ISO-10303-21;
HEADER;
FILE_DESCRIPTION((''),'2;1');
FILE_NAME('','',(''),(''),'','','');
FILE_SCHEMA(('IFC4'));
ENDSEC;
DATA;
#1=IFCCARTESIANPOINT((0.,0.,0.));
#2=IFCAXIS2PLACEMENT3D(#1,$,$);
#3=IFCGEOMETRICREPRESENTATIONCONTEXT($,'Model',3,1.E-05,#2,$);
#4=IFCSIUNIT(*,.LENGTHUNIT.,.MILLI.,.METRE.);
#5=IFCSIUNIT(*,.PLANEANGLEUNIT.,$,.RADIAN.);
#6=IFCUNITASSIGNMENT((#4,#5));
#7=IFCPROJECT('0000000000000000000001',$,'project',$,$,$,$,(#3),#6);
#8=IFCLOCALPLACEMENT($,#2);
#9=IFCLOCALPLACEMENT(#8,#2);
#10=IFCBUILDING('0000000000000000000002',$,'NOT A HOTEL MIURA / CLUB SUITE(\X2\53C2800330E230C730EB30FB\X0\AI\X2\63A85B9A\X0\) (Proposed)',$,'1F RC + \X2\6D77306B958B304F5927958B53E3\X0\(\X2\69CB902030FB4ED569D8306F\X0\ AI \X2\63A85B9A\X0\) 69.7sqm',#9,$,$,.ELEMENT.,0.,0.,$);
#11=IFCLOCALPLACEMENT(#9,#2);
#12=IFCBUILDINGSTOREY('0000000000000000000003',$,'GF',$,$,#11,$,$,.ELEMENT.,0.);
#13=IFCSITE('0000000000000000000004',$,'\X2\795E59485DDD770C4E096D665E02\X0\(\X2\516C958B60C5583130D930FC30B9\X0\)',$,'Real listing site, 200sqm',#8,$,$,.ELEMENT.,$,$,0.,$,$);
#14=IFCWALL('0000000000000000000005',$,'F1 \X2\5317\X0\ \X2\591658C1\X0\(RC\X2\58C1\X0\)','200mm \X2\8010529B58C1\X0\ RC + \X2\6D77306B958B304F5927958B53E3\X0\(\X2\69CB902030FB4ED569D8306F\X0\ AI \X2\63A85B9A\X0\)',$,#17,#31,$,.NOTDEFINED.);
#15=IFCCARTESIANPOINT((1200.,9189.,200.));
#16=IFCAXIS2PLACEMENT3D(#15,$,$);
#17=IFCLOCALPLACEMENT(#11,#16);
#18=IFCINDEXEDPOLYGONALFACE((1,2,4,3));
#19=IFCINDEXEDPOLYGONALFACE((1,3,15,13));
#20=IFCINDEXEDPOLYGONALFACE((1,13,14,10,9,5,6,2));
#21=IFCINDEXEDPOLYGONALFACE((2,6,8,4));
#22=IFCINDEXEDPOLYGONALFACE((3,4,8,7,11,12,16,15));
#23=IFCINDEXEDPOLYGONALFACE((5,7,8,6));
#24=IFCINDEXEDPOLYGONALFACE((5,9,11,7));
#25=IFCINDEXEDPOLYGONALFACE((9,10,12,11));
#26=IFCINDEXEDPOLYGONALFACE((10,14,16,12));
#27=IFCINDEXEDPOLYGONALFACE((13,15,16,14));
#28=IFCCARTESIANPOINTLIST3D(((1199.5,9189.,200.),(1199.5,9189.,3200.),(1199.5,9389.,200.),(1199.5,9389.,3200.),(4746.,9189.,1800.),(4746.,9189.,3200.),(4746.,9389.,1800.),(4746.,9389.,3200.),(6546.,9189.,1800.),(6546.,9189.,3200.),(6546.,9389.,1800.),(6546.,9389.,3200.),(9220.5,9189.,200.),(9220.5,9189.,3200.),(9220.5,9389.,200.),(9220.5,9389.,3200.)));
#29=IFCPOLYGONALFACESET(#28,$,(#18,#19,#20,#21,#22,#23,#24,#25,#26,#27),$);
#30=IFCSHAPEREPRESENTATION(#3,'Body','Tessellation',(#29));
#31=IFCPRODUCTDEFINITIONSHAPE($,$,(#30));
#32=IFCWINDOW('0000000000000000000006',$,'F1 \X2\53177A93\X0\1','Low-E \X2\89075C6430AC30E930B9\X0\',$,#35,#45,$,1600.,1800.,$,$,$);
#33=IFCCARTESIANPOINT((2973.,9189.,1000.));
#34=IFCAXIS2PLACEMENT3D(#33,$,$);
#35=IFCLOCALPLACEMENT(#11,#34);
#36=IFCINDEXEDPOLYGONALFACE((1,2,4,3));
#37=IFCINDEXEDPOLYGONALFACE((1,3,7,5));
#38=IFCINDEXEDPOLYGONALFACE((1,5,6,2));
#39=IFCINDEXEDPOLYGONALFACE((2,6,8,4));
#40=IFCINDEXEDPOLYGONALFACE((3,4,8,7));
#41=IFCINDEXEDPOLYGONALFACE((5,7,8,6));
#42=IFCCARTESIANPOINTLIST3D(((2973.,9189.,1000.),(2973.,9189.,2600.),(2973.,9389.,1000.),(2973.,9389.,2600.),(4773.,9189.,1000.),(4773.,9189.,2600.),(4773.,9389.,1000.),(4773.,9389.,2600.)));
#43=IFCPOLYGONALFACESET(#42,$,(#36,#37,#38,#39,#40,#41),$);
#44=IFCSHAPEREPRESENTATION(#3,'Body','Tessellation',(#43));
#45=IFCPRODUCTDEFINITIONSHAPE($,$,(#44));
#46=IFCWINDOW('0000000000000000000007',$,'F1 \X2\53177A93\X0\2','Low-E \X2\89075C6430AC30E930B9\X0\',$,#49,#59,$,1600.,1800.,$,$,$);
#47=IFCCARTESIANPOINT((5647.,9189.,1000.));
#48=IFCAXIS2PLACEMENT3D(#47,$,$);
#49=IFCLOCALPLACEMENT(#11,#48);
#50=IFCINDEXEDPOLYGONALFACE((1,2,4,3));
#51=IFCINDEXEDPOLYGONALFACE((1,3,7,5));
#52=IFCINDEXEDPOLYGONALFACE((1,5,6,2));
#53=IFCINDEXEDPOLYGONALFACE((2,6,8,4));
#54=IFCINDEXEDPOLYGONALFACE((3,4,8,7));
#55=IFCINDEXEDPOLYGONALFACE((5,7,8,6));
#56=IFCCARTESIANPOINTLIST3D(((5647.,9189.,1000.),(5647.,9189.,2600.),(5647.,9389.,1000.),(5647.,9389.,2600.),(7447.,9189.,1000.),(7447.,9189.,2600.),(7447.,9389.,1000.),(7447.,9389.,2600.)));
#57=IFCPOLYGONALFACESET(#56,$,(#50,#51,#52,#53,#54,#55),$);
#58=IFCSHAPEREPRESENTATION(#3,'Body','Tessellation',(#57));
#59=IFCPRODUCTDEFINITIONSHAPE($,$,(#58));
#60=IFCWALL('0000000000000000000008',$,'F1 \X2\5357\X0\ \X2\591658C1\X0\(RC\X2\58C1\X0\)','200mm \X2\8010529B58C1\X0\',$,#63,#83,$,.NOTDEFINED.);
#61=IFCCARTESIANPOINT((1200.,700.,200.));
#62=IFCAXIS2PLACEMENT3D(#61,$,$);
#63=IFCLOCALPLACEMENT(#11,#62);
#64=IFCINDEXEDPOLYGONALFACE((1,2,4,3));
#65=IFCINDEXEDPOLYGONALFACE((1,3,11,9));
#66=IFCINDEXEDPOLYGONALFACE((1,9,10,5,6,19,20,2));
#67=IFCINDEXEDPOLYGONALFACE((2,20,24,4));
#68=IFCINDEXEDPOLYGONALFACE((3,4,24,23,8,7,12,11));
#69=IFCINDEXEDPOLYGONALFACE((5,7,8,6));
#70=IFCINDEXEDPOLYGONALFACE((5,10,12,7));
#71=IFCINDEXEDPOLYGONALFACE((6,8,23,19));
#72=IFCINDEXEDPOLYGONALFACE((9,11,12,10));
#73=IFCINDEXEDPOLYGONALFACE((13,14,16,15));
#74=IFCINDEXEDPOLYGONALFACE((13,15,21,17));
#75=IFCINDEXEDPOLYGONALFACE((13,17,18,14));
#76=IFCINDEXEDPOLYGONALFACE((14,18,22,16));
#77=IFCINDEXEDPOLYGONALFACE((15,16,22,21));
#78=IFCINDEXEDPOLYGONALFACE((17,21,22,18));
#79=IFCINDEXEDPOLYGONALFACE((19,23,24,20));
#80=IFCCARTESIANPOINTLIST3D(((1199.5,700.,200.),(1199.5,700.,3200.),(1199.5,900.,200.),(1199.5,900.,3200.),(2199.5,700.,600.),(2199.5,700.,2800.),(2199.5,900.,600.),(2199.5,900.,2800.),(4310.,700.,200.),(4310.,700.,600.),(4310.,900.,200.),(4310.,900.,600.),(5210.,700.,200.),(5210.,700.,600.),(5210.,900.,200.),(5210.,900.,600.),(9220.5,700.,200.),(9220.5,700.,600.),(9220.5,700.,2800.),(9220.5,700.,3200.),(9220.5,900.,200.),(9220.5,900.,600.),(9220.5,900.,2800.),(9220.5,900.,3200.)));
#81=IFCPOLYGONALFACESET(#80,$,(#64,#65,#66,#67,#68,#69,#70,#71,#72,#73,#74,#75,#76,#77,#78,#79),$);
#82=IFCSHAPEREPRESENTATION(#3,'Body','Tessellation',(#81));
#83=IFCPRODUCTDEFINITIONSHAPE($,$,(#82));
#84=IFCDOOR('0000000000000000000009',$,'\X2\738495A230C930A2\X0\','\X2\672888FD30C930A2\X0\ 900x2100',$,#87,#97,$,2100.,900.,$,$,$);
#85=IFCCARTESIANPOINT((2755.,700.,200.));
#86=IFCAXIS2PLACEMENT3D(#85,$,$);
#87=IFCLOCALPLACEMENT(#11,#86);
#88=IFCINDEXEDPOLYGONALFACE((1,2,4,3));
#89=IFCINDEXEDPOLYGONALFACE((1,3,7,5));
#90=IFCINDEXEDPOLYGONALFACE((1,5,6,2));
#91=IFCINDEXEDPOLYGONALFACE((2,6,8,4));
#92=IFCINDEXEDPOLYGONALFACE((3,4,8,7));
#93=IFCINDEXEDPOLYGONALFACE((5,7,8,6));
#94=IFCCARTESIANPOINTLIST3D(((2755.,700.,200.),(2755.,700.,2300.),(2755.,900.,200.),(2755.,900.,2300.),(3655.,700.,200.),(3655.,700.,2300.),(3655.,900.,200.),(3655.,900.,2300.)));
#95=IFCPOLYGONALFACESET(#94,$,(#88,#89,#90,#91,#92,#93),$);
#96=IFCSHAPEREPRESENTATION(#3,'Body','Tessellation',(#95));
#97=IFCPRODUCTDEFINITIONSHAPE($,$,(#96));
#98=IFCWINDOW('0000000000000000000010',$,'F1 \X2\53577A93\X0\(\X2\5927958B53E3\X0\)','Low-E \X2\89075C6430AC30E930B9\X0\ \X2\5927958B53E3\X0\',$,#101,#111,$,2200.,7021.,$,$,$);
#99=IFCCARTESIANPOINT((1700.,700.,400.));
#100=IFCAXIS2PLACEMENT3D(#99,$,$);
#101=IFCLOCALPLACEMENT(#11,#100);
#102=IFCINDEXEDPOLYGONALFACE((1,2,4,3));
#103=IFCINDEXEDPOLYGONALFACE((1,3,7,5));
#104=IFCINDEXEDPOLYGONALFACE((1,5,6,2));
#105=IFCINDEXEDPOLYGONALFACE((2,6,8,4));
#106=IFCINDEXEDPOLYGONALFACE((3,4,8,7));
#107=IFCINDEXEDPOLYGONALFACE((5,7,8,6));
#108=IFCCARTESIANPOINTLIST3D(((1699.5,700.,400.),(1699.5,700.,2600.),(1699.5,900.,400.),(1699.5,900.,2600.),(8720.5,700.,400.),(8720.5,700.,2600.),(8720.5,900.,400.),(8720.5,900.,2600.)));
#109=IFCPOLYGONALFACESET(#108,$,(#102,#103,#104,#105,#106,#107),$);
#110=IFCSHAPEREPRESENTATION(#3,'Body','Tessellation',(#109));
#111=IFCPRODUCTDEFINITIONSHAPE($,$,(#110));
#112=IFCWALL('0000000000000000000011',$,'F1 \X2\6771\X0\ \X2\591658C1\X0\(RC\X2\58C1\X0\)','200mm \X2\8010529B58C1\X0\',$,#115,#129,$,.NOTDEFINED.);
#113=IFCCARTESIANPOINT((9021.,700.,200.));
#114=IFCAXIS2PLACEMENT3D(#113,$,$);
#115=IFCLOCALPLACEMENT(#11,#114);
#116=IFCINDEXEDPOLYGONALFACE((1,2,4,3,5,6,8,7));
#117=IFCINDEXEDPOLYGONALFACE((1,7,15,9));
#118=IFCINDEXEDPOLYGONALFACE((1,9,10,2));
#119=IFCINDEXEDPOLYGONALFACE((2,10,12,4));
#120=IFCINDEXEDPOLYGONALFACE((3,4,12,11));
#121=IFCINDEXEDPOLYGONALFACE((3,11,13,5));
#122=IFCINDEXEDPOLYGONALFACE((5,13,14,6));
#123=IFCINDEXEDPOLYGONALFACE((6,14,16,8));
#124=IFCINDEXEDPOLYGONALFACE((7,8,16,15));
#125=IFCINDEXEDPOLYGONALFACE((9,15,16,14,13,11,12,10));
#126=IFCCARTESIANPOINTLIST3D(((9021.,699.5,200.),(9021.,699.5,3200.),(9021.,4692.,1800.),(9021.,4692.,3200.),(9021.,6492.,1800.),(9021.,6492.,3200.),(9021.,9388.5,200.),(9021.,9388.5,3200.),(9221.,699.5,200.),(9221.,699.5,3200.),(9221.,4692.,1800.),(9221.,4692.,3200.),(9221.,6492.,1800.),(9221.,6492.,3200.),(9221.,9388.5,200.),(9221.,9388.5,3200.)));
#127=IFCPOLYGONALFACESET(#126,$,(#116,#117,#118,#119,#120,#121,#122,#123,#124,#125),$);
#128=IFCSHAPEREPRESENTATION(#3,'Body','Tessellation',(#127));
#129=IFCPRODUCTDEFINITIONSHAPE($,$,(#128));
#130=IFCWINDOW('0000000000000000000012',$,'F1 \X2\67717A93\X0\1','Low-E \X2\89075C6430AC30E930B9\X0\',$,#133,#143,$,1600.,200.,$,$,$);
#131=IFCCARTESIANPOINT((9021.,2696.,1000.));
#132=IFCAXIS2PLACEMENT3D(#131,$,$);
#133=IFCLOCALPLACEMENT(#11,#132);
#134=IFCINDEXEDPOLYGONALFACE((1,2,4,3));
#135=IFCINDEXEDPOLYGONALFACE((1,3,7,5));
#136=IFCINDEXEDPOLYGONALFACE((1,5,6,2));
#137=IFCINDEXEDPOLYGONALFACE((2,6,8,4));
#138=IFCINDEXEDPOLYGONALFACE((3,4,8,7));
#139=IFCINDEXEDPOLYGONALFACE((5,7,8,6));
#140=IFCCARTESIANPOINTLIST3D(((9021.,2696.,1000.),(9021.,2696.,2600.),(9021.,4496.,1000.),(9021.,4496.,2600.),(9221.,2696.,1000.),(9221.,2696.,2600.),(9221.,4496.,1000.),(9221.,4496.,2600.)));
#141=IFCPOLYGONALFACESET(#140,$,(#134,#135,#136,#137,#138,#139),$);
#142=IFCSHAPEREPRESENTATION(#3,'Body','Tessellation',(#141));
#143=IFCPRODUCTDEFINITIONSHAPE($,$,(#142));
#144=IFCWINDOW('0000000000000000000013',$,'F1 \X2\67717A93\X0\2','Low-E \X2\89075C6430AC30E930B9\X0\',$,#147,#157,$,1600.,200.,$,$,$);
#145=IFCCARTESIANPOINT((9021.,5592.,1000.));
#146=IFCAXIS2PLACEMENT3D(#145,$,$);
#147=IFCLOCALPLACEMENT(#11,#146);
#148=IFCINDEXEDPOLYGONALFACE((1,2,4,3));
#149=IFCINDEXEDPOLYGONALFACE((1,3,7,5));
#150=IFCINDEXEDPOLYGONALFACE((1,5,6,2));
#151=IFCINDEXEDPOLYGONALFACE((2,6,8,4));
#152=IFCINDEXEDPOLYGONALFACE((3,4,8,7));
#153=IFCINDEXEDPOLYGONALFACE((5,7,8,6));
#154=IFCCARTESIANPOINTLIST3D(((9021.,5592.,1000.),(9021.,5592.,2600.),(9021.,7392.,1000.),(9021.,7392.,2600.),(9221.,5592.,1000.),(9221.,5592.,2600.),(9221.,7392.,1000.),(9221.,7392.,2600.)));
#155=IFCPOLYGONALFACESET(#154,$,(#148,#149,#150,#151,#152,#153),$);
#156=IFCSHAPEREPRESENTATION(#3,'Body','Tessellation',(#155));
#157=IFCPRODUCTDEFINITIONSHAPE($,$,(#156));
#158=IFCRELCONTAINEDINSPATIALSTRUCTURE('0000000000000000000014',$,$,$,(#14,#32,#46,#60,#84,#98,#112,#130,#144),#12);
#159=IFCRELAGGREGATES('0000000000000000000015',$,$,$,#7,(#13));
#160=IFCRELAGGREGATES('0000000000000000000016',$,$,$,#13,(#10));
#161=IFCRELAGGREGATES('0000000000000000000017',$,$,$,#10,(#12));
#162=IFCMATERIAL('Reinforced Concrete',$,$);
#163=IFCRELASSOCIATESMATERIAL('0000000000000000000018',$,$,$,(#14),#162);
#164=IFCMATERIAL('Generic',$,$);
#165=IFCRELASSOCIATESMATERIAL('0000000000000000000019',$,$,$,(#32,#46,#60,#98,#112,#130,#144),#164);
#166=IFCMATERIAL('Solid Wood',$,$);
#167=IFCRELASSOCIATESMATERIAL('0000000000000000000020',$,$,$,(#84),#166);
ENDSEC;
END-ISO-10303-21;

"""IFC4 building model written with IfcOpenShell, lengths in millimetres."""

from ifc_helpers import new_model, si_unit, frame, frame_2d, origin, place, context, project, spatial, rectangle, extrude, material, element, fill, save


model = new_model("IFC4")

# Units and contexts
model_context = context("Model", 3, precision=1e-05, world=origin())
ifc_project = project(units=[si_unit("LENGTHUNIT", "METRE", prefix="MILLI"), si_unit("PLANEANGLEUNIT", "RADIAN")], contexts=[model_context])

# Site, building, storey
site_placement = place(None, origin())
site = spatial("IfcSite", under=ifc_project, at=site_placement, Name="神奈川県三浦市(公開情報ベース)", ObjectType="Real listing site, 200sqm", CompositionType="ELEMENT", RefElevation=0.0)
building_placement = place(site_placement, origin())
building = spatial("IfcBuilding", under=site, at=building_placement, Name="NOT A HOTEL MIURA / CLUB SUITE(参考モデル・AI推定) (Proposed)", ObjectType="1F RC + 海に開く大開口(構造・仕様は AI 推定) 69.7sqm", CompositionType="ELEMENT", ElevationOfRefHeight=0.0, ElevationOfTerrain=0.0)
storey_placement = place(building_placement, origin())
storey = spatial("IfcBuildingStorey", under=building, at=storey_placement, Name="GF", CompositionType="ELEMENT", Elevation=0.0)

# Shared definitions
ifc_material_1 = material(Name="Reinforced Concrete")

# Wall, openings, windows
wall_1_placement = place(storey_placement, frame((1200.0, 9189.0, 200.0)))
wall_1 = element("IfcWall", 1, at=wall_1_placement, inside=storey, material=ifc_material_1, Name="F1 北 外壁(RC壁)", Description="200mm 耐力壁 RC + 海に開く大開口(構造・仕様は AI 推定)", PredefinedType="NOTDEFINED", context=model_context, shape_type="SweptSolid", body=[
    extrude(rectangle(XDim=8021.0, YDim=200.0, at=frame_2d((4010.0, 100.0))), frame((1200.0, 9189.0, 200.0)), (0.0, 0.0, 1.0), 3000.0),
])
opening_1_placement = place(storey_placement, frame((2973.0, 9189.0, 1000.0)))
opening_1 = element("IfcOpeningElement", 2, at=opening_1_placement, cuts=wall_1, PredefinedType="NOTDEFINED", context=model_context, shape_type="SweptSolid", body=[
    extrude(rectangle(XDim=1800.0, YDim=200.0, at=frame_2d((900.0, 100.0))), frame((2973.0, 9189.0, 1000.0)), (0.0, 0.0, 1.0), 1600.0),
])
opening_2_placement = place(storey_placement, frame((5647.0, 9189.0, 1000.0)))
opening_2 = element("IfcOpeningElement", 3, at=opening_2_placement, cuts=wall_1, PredefinedType="NOTDEFINED", context=model_context, shape_type="SweptSolid", body=[
    extrude(rectangle(XDim=1800.0, YDim=200.0, at=frame_2d((900.0, 100.0))), frame((5647.0, 9189.0, 1000.0)), (0.0, 0.0, 1.0), 1600.0),
])
ifc_material_2 = material(Name="Generic")
window_1_placement = place(storey_placement, frame((2973.0, 9189.0, 1000.0)))
window_1 = element("IfcWindow", 4, at=window_1_placement, inside=storey, material=ifc_material_2, Name="F1 北窓1", Description="Low-E 複層ガラス", OverallHeight=1600.0, OverallWidth=1800.0, context=model_context, shape_type="SweptSolid", body=[
    extrude(rectangle(XDim=1800.0, YDim=200.0, at=frame_2d((900.0, 100.0))), frame((2973.0, 9189.0, 1000.0)), (0.0, 0.0, 1.0), 1600.0),
])
fill(opening_1, window_1)
window_2_placement = place(storey_placement, frame((5647.0, 9189.0, 1000.0)))
window_2 = element("IfcWindow", 5, at=window_2_placement, inside=storey, material=ifc_material_2, Name="F1 北窓2", Description="Low-E 複層ガラス", OverallHeight=1600.0, OverallWidth=1800.0, context=model_context, shape_type="SweptSolid", body=[
    extrude(rectangle(XDim=1800.0, YDim=200.0, at=frame_2d((900.0, 100.0))), frame((5647.0, 9189.0, 1000.0)), (0.0, 0.0, 1.0), 1600.0),
])
fill(opening_2, window_2)

# Wall, openings, door, window
wall_2_placement = place(storey_placement, frame((1200.0, 700.0, 200.0)))
wall_2 = element("IfcWall", 6, at=wall_2_placement, inside=storey, material=ifc_material_2, Name="F1 南 外壁(RC壁)", Description="200mm 耐力壁", PredefinedType="NOTDEFINED", context=model_context, shape_type="SweptSolid", body=[
    extrude(rectangle(XDim=8021.0, YDim=200.0, at=frame_2d((4010.0, 100.0))), frame((1200.0, 700.0, 200.0)), (0.0, 0.0, 1.0), 3000.0),
])
opening_3_placement = place(storey_placement, frame((2755.0, 700.0, 200.0)))
opening_3 = element("IfcOpeningElement", 7, at=opening_3_placement, cuts=wall_2, PredefinedType="NOTDEFINED", context=model_context, shape_type="SweptSolid", body=[
    extrude(rectangle(XDim=900.0, YDim=200.0, at=frame_2d((450.0, 100.0))), frame((2755.0, 700.0, 200.0)), (0.0, 0.0, 1.0), 2100.0),
])
opening_4_placement = place(storey_placement, frame((1700.0, 700.0, 400.0)))
opening_4 = element("IfcOpeningElement", 8, at=opening_4_placement, cuts=wall_2, PredefinedType="NOTDEFINED", context=model_context, shape_type="SweptSolid", body=[
    extrude(rectangle(XDim=7021.0, YDim=200.0, at=frame_2d((3510.0, 100.0))), frame((1700.0, 700.0, 400.0)), (0.0, 0.0, 1.0), 2200.0),
])
ifc_material_3 = material(Name="Solid Wood")
door_placement = place(storey_placement, frame((2755.0, 700.0, 200.0)))
door = element("IfcDoor", 9, at=door_placement, inside=storey, material=ifc_material_3, Name="玄関ドア", Description="木製ドア 900x2100", OverallHeight=2100.0, OverallWidth=900.0, context=model_context, shape_type="SweptSolid", body=[
    extrude(rectangle(XDim=900.0, YDim=200.0, at=frame_2d((450.0, 100.0))), frame((2755.0, 700.0, 200.0)), (0.0, 0.0, 1.0), 2100.0),
])
fill(opening_3, door)
window_3_placement = place(storey_placement, frame((1700.0, 700.0, 400.0)))
window_3 = element("IfcWindow", 10, at=window_3_placement, inside=storey, material=ifc_material_2, Name="F1 南窓(大開口)", Description="Low-E 複層ガラス 大開口", OverallHeight=2200.0, OverallWidth=7021.0, context=model_context, shape_type="SweptSolid", body=[
    extrude(rectangle(XDim=7021.0, YDim=200.0, at=frame_2d((3510.0, 100.0))), frame((1700.0, 700.0, 400.0)), (0.0, 0.0, 1.0), 2200.0),
])
fill(opening_4, window_3)

# Wall, openings, windows
wall_3_placement = place(storey_placement, frame((9021.0, 700.0, 200.0)))
wall_3 = element("IfcWall", 11, at=wall_3_placement, inside=storey, material=ifc_material_2, Name="F1 東 外壁(RC壁)", Description="200mm 耐力壁", PredefinedType="NOTDEFINED", context=model_context, shape_type="SweptSolid", body=[
    extrude(rectangle(XDim=200.0, YDim=8689.0, at=frame_2d((100.0, 4344.0))), frame((9021.0, 700.0, 200.0)), (0.0, 0.0, 1.0), 3000.0),
])
opening_5_placement = place(storey_placement, frame((9021.0, 2696.0, 1000.0)))
opening_5 = element("IfcOpeningElement", 12, at=opening_5_placement, cuts=wall_3, PredefinedType="NOTDEFINED", context=model_context, shape_type="SweptSolid", body=[
    extrude(rectangle(XDim=200.0, YDim=1800.0, at=frame_2d((100.0, 900.0))), frame((9021.0, 2696.0, 1000.0)), (0.0, 0.0, 1.0), 1600.0),
])
opening_6_placement = place(storey_placement, frame((9021.0, 5592.0, 1000.0)))
opening_6 = element("IfcOpeningElement", 13, at=opening_6_placement, cuts=wall_3, PredefinedType="NOTDEFINED", context=model_context, shape_type="SweptSolid", body=[
    extrude(rectangle(XDim=200.0, YDim=1800.0, at=frame_2d((100.0, 900.0))), frame((9021.0, 5592.0, 1000.0)), (0.0, 0.0, 1.0), 1600.0),
])
window_4_placement = place(storey_placement, frame((9021.0, 2696.0, 1000.0)))
window_4 = element("IfcWindow", 14, at=window_4_placement, inside=storey, material=ifc_material_2, Name="F1 東窓1", Description="Low-E 複層ガラス", OverallHeight=1600.0, OverallWidth=200.0, context=model_context, shape_type="SweptSolid", body=[
    extrude(rectangle(XDim=200.0, YDim=1800.0, at=frame_2d((100.0, 900.0))), frame((9021.0, 2696.0, 1000.0)), (0.0, 0.0, 1.0), 1600.0),
])
fill(opening_5, window_4)
window_5_placement = place(storey_placement, frame((9021.0, 5592.0, 1000.0)))
window_5 = element("IfcWindow", 15, at=window_5_placement, inside=storey, material=ifc_material_2, Name="F1 東窓2", Description="Low-E 複層ガラス", OverallHeight=1600.0, OverallWidth=200.0, context=model_context, shape_type="SweptSolid", body=[
    extrude(rectangle(XDim=200.0, YDim=1800.0, at=frame_2d((100.0, 900.0))), frame((9021.0, 5592.0, 1000.0)), (0.0, 0.0, 1.0), 1600.0),
])
fill(opening_6, window_5)

save(model, "model.ifc")
